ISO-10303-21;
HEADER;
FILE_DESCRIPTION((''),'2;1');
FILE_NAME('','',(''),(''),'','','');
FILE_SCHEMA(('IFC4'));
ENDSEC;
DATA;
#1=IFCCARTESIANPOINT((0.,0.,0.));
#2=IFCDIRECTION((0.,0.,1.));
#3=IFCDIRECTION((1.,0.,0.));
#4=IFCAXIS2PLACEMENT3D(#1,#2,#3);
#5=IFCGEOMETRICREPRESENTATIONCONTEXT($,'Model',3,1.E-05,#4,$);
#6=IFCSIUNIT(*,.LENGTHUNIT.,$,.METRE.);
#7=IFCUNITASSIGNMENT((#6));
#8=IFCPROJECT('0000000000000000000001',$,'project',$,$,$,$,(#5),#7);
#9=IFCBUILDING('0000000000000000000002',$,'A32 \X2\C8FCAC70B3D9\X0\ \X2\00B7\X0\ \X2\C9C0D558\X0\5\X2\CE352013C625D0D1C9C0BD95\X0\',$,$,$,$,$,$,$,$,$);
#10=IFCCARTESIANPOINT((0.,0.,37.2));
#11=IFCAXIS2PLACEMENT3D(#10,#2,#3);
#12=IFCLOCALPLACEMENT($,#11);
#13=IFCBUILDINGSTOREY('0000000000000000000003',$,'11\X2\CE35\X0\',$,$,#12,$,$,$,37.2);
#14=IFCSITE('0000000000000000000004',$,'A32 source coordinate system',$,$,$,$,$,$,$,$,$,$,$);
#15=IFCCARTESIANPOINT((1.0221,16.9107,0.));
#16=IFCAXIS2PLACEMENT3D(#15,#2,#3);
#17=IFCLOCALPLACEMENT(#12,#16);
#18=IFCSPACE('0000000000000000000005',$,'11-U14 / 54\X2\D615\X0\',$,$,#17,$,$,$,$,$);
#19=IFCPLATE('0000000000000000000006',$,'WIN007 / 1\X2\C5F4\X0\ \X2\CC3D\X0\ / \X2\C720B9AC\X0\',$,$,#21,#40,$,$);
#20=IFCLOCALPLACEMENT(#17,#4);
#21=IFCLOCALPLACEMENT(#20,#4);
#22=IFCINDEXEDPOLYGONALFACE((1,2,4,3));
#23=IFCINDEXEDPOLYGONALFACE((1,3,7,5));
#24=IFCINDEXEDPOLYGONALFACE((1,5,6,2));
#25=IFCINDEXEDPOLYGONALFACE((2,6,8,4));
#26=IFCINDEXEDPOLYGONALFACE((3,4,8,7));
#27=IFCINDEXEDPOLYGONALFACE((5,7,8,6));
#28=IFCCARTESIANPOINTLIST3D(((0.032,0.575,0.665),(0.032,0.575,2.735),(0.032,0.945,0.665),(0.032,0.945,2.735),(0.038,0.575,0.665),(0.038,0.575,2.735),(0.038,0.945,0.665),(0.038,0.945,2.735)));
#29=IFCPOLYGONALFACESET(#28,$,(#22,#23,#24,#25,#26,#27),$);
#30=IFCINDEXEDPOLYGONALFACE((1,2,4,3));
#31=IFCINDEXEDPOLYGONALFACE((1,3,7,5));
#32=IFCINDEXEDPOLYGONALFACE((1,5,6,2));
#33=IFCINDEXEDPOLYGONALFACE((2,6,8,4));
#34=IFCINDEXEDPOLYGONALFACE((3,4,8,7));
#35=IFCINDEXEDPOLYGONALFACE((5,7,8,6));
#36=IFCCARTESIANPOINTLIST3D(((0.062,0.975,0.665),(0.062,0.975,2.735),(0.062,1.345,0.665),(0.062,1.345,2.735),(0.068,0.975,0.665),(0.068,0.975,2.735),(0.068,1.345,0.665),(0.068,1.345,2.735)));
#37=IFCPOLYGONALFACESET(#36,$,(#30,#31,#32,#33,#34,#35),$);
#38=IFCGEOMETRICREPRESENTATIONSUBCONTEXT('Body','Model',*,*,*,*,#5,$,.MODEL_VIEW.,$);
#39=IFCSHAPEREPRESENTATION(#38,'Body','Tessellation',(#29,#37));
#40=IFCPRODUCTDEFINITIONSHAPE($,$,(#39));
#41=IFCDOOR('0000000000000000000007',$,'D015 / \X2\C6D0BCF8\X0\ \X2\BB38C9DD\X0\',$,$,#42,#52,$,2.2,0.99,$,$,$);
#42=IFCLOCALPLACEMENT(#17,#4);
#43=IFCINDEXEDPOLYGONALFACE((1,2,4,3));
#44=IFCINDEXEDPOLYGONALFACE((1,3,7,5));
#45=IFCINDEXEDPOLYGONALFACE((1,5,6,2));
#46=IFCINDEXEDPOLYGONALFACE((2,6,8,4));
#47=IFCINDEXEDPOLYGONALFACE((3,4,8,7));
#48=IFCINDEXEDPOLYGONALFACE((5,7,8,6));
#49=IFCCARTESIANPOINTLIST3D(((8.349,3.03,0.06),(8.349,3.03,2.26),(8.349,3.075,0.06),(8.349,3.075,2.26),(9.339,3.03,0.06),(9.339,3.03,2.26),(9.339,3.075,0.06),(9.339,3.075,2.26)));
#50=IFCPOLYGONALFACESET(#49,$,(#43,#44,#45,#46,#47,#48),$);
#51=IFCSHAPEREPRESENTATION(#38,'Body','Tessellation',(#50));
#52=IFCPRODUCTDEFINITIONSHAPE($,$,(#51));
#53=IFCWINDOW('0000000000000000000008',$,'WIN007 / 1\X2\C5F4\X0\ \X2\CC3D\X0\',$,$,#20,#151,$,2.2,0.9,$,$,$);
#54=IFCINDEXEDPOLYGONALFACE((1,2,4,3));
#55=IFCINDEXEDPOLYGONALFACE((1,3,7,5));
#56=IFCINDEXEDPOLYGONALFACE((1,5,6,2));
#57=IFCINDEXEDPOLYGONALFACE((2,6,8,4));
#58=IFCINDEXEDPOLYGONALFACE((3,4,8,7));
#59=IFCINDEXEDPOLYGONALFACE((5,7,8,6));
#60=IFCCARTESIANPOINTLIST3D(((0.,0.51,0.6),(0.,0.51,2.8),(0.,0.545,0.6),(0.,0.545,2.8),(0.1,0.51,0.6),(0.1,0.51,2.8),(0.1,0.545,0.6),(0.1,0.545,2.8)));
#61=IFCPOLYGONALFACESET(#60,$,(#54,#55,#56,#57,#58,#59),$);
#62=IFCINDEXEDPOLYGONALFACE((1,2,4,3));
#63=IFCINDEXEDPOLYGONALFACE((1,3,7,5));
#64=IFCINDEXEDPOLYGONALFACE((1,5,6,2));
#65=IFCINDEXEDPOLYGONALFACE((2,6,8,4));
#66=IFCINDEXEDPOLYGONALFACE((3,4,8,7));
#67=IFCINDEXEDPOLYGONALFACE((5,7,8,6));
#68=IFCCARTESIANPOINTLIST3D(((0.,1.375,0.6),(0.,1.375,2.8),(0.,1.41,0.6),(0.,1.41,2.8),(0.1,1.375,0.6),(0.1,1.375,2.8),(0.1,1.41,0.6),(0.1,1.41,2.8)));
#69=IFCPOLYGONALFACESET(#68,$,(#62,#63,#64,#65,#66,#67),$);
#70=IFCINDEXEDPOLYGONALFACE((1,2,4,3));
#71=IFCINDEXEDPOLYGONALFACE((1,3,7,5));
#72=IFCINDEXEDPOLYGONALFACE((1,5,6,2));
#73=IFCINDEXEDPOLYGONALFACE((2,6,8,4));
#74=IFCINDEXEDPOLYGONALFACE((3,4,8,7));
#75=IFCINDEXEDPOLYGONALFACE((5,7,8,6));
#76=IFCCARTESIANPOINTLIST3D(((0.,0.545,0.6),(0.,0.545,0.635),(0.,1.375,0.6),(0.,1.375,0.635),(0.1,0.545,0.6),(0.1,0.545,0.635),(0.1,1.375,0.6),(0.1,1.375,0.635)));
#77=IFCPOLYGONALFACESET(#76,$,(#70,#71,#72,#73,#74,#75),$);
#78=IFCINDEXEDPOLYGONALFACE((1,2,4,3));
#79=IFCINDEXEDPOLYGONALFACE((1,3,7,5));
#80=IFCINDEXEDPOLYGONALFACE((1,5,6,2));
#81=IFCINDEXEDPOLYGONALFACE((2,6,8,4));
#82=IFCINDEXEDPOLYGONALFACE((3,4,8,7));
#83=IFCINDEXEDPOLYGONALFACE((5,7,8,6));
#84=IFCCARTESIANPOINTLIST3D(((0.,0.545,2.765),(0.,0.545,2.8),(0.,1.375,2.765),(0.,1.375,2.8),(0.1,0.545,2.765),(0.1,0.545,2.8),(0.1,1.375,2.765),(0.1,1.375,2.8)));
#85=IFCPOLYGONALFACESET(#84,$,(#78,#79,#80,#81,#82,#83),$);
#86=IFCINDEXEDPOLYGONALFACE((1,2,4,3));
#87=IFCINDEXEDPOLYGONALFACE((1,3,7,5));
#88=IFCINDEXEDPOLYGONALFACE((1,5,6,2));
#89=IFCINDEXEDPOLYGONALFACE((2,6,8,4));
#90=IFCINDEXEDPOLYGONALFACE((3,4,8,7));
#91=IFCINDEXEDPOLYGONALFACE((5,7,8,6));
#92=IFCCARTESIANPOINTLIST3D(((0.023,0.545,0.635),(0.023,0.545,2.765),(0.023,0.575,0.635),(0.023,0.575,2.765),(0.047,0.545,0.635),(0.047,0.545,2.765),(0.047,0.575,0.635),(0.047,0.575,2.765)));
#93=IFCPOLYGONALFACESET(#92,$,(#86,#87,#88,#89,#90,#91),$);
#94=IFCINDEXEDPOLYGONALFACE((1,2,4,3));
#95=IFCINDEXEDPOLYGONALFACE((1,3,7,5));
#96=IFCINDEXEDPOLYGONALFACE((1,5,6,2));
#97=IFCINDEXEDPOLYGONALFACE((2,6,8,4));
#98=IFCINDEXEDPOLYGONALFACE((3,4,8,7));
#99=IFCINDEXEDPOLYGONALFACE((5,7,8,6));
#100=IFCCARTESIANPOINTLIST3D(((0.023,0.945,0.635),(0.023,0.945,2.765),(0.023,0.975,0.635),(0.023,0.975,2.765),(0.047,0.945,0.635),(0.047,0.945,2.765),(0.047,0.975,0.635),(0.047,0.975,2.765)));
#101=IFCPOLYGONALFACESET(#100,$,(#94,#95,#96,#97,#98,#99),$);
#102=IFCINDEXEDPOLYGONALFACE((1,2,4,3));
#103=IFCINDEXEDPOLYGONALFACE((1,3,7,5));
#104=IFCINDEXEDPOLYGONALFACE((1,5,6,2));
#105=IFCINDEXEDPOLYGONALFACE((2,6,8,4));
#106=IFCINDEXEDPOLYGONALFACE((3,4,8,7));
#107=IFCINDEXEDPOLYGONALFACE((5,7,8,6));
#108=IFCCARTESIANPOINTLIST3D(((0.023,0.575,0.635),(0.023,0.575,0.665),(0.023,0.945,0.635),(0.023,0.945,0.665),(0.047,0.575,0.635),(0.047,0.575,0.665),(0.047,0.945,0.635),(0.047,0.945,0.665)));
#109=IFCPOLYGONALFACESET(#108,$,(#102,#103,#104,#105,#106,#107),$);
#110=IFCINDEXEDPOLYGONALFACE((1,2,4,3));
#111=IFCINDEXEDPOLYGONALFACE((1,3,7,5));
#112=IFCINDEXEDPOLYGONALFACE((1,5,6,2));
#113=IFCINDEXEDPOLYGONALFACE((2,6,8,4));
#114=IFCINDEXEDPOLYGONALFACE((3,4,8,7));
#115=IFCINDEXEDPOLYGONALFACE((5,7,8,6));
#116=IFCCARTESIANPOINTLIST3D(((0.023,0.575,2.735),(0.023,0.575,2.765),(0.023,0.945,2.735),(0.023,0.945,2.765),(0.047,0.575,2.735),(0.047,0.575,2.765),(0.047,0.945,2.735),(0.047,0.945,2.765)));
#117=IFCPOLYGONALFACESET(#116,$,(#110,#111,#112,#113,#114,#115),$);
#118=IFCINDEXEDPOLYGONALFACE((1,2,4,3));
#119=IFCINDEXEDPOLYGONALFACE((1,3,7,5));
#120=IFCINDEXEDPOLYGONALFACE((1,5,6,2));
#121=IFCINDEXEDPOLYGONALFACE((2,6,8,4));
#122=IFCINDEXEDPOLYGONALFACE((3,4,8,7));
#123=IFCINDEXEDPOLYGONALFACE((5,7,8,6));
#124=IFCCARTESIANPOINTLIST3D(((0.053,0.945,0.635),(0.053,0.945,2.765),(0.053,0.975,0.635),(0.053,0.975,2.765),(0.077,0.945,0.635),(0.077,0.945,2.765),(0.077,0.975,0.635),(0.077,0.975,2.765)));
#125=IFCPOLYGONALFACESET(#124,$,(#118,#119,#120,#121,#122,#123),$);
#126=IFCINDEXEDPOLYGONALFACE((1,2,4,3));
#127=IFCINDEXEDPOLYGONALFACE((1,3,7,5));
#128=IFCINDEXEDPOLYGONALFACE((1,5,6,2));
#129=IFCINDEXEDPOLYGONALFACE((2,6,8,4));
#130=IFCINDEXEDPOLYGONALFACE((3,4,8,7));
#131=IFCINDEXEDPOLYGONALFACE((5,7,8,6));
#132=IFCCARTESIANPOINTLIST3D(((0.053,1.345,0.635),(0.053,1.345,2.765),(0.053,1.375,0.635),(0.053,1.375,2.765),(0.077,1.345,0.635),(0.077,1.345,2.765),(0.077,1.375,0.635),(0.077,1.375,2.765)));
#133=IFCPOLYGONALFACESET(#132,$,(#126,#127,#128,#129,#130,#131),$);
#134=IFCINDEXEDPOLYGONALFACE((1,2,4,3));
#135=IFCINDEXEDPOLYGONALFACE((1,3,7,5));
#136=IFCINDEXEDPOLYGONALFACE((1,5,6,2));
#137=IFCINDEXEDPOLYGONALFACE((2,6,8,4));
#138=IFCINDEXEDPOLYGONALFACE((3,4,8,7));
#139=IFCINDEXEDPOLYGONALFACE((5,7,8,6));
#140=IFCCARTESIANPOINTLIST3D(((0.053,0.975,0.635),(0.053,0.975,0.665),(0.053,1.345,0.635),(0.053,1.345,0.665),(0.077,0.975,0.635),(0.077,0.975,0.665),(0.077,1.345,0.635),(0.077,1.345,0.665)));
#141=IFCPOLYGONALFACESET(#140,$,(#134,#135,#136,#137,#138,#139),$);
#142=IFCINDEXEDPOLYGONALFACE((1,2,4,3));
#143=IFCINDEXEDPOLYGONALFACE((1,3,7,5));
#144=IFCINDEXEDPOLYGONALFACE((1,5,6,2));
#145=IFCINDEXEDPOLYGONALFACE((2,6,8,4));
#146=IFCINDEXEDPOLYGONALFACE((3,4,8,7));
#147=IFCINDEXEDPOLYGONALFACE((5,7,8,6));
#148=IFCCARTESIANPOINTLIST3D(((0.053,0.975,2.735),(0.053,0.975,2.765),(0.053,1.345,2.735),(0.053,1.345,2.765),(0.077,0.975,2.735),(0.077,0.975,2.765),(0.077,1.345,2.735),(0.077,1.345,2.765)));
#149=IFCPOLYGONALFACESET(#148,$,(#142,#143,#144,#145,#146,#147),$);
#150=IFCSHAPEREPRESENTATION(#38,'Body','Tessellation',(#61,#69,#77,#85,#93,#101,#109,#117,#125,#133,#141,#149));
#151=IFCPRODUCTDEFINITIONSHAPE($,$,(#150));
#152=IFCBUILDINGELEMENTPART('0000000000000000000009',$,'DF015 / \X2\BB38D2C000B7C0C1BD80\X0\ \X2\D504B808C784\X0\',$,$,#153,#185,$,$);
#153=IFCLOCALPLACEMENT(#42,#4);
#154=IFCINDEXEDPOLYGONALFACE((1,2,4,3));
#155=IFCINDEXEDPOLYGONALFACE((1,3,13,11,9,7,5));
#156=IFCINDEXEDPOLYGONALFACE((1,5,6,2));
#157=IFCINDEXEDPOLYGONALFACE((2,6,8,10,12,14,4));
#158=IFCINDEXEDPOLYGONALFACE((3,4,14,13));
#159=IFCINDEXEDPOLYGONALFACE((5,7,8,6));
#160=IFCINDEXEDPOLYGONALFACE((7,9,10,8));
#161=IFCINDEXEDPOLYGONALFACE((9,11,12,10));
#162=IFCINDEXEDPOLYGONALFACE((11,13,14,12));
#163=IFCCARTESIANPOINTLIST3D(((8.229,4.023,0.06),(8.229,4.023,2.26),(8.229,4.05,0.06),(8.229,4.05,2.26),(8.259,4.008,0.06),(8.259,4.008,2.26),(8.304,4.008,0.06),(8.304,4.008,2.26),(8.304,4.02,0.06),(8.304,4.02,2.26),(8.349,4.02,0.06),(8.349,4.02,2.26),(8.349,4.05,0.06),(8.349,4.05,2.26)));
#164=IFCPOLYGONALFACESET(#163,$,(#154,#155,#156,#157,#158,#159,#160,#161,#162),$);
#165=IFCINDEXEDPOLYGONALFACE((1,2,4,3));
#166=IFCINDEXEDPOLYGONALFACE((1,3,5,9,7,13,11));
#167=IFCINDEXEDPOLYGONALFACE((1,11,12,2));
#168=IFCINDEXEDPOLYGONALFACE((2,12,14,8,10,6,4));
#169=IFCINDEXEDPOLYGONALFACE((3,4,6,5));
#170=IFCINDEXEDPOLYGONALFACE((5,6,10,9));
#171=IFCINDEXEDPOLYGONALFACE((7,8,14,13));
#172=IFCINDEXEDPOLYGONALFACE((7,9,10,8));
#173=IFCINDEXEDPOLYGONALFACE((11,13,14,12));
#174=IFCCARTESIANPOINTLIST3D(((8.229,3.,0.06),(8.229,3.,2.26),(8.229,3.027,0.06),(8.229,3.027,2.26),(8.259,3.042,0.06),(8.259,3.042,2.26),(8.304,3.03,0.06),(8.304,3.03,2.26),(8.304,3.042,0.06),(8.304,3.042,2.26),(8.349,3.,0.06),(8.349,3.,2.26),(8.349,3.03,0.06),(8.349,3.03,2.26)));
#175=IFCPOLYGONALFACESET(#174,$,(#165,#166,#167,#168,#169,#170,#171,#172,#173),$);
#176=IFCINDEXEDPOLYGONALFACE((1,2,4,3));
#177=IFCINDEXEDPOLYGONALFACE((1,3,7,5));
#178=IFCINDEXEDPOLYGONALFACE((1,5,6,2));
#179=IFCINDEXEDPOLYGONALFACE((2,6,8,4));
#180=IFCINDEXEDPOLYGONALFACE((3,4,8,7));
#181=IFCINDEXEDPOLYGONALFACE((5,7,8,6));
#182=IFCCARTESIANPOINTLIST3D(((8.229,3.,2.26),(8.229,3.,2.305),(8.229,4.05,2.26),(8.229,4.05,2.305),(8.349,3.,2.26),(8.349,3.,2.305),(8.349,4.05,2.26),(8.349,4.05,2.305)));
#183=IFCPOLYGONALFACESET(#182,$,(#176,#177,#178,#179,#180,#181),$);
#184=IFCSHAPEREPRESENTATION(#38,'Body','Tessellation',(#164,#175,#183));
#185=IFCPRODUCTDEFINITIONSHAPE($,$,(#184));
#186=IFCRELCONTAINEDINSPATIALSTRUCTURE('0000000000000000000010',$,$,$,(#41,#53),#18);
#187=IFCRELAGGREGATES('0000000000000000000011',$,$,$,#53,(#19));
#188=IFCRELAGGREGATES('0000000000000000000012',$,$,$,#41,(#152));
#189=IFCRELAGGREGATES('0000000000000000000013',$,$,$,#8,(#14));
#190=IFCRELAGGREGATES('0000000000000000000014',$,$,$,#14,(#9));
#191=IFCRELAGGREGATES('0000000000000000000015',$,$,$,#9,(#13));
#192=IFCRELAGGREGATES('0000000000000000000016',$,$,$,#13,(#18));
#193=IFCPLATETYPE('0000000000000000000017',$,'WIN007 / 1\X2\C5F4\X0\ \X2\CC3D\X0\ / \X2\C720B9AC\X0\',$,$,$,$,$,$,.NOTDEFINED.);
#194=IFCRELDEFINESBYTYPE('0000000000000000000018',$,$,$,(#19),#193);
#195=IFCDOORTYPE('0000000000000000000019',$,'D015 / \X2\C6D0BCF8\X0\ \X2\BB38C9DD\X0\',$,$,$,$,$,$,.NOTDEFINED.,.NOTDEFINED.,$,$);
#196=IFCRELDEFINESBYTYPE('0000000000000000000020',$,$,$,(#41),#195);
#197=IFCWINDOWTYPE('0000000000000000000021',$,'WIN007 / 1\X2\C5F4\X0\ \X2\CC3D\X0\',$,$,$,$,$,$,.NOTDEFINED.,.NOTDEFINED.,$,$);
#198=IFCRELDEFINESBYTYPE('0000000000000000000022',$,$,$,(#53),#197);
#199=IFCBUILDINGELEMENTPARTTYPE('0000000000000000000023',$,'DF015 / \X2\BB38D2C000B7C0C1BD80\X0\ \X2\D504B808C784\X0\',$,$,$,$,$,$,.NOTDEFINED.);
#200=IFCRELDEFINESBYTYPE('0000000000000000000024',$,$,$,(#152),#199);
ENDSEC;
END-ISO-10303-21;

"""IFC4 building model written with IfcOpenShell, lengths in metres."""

from ifc_helpers import new_model, si_unit, frame, origin, origin_with_axes, place, context, subcontext, project, spatial, polyline, outline, extrude, source, transform, mapped, type_object, type_shapes, element, aggregate, save


model = new_model("IFC4")

# Units and contexts
model_context = context("Model", 3, precision=1e-05, world=origin_with_axes())
body_context = subcontext(model_context, "Body", "Model", "MODEL_VIEW")
ifc_project = project(units=[si_unit("LENGTHUNIT", "METRE")], contexts=[model_context])

# Plate
plate_type_1 = type_object("IfcPlateType", Name="WIN007 / 1열 창 / 유리", PredefinedType="NOTDEFINED")
shared_shape_1 = source(origin(), body_context, "Body", "SweptSolid", [
    extrude(outline(polyline([(0.032, 0.575), (0.032, 0.945), (0.038, 0.945), (0.038, 0.575), (0.032, 0.575)])), frame((0.0, 0.0, 0.665)), (0.0, 0.0, 1.0), 2.07),
    extrude(outline(polyline([(0.062, 0.975), (0.062, 1.345), (0.068, 1.345), (0.068, 0.975), (0.062, 0.975)])), frame((0.0, 0.0, 0.665)), (0.0, 0.0, 1.0), 2.07),
])
type_shapes(plate_type_1, [shared_shape_1])
storey_placement = place(None, frame((0.0, 0.0, 37.2), z_axis=(0.0, 0.0, 1.0), x_axis=(1.0, 0.0, 0.0)))
space_1_placement = place(storey_placement, frame((1.0221, 16.9107, 0.0), z_axis=(0.0, 0.0, 1.0), x_axis=(1.0, 0.0, 0.0)))
window_1_placement = place(space_1_placement, origin_with_axes())
plate_1_placement = place(window_1_placement, origin_with_axes())
plate_1 = element("IfcPlate", 1, at=plate_1_placement, type_object=plate_type_1, Name="WIN007 / 1열 창 / 유리", context=body_context, shape_type="MappedRepresentation", body=[
    mapped(shared_shape_1, transform((0.0, 0.0, 0.0), scale=1.0)),
])

# Site, building, storey, space
site = spatial("IfcSite", under=ifc_project, Name="A32 source coordinate system")
building = spatial("IfcBuilding", under=site, Name="A32 주거동 · 지하5층–옥탑지붕")
storey = spatial("IfcBuildingStorey", under=building, at=storey_placement, Name="11층", Elevation=37.2)
space_1 = spatial("IfcSpace", under=storey, at=space_1_placement, Name="11-U14 / 54형")

# Door
door_type_1 = type_object("IfcDoorType", Name="D015 / 원본 문짝", OperationType="NOTDEFINED", PredefinedType="NOTDEFINED")
shared_shape_2 = source(origin(), body_context, "Body", "SweptSolid", [
    extrude(outline(polyline([(9.339, 3.075), (9.339, 3.03), (8.349, 3.03), (8.349, 3.075), (9.339, 3.075)])), frame((0.0, 0.0, 0.06)), (0.0, 0.0, 1.0), 2.2),
])
type_shapes(door_type_1, [shared_shape_2])
door_1_placement = place(space_1_placement, origin_with_axes())
door_1 = element("IfcDoor", 2, at=door_1_placement, inside=space_1, type_object=door_type_1, Name="D015 / 원본 문짝", OverallHeight=2.2, OverallWidth=0.99, context=body_context, shape_type="MappedRepresentation", body=[
    mapped(shared_shape_2, transform((0.0, 0.0, 0.0), scale=1.0)),
])

# Window
window_type_1 = type_object("IfcWindowType", Name="WIN007 / 1열 창", PartitioningType="NOTDEFINED", PredefinedType="NOTDEFINED")
shared_shape_3 = source(origin(), body_context, "Body", "SweptSolid", [
    extrude(outline(polyline([(0.0, 0.51), (0.0, 0.545), (0.1, 0.545), (0.1, 0.51), (0.0, 0.51)])), frame((0.0, 0.0, 0.6)), (0.0, 0.0, 1.0), 2.2),
    extrude(outline(polyline([(0.0, 1.375), (0.0, 1.41), (0.1, 1.41), (0.1, 1.375), (0.0, 1.375)])), frame((0.0, 0.0, 0.6)), (0.0, 0.0, 1.0), 2.2),
    extrude(outline(polyline([(0.0, 0.545), (0.0, 1.375), (0.1, 1.375), (0.1, 0.545), (0.0, 0.545)])), frame((0.0, 0.0, 0.6)), (0.0, 0.0, 1.0), 0.035),
    extrude(outline(polyline([(0.0, 0.545), (0.0, 1.375), (0.1, 1.375), (0.1, 0.545), (0.0, 0.545)])), frame((0.0, 0.0, 2.765)), (0.0, 0.0, 1.0), 0.035),
    extrude(outline(polyline([(0.023, 0.545), (0.023, 0.575), (0.047, 0.575), (0.047, 0.545), (0.023, 0.545)])), frame((0.0, 0.0, 0.635)), (0.0, 0.0, 1.0), 2.13),
    extrude(outline(polyline([(0.023, 0.945), (0.023, 0.975), (0.047, 0.975), (0.047, 0.945), (0.023, 0.945)])), frame((0.0, 0.0, 0.635)), (0.0, 0.0, 1.0), 2.13),
    extrude(outline(polyline([(0.023, 0.575), (0.023, 0.945), (0.047, 0.945), (0.047, 0.575), (0.023, 0.575)])), frame((0.0, 0.0, 0.635)), (0.0, 0.0, 1.0), 0.03),
    extrude(outline(polyline([(0.023, 0.575), (0.023, 0.945), (0.047, 0.945), (0.047, 0.575), (0.023, 0.575)])), frame((0.0, 0.0, 2.735)), (0.0, 0.0, 1.0), 0.03),
    extrude(outline(polyline([(0.053, 0.945), (0.053, 0.975), (0.077, 0.975), (0.077, 0.945), (0.053, 0.945)])), frame((0.0, 0.0, 0.635)), (0.0, 0.0, 1.0), 2.13),
    extrude(outline(polyline([(0.053, 1.345), (0.053, 1.375), (0.077, 1.375), (0.077, 1.345), (0.053, 1.345)])), frame((0.0, 0.0, 0.635)), (0.0, 0.0, 1.0), 2.13),
    extrude(outline(polyline([(0.053, 0.975), (0.053, 1.345), (0.077, 1.345), (0.077, 0.975), (0.053, 0.975)])), frame((0.0, 0.0, 0.635)), (0.0, 0.0, 1.0), 0.03),
    extrude(outline(polyline([(0.053, 0.975), (0.053, 1.345), (0.077, 1.345), (0.077, 0.975), (0.053, 0.975)])), frame((0.0, 0.0, 2.735)), (0.0, 0.0, 1.0), 0.03),
])
type_shapes(window_type_1, [shared_shape_3])
window_1 = element("IfcWindow", 3, at=window_1_placement, inside=space_1, type_object=window_type_1, Name="WIN007 / 1열 창", OverallHeight=2.2, OverallWidth=0.9, context=body_context, shape_type="MappedRepresentation", body=[
    mapped(shared_shape_3, transform((0.0, 0.0, 0.0), scale=1.0)),
])
aggregate(window_1, [plate_1])

# Building element part
building_element_part_type_1 = type_object("IfcBuildingElementPartType", Name="DF015 / 문틀·상부 프레임", PredefinedType="NOTDEFINED")
shared_shape_4 = source(origin(), body_context, "Body", "SweptSolid", [
    extrude(outline(polyline([(8.349, 4.02), (8.304, 4.02), (8.304, 4.008), (8.259, 4.008), (8.229, 4.023), (8.229, 4.05), (8.349, 4.05), (8.349, 4.02)])), frame((0.0, 0.0, 0.06)), (0.0, 0.0, 1.0), 2.2),
    extrude(outline(polyline([(8.229, 3.0), (8.229, 3.027), (8.259, 3.042), (8.304, 3.042), (8.304, 3.03), (8.349, 3.03), (8.349, 3.0), (8.229, 3.0)])), frame((0.0, 0.0, 0.06)), (0.0, 0.0, 1.0), 2.2),
    extrude(outline(polyline([(8.229, 3.0), (8.229, 4.05), (8.349, 4.05), (8.349, 3.0), (8.229, 3.0)])), frame((0.0, 0.0, 2.26)), (0.0, 0.0, 1.0), 0.045),
])
type_shapes(building_element_part_type_1, [shared_shape_4])
building_element_part_1_placement = place(door_1_placement, origin_with_axes())
building_element_part_1 = element("IfcBuildingElementPart", 4, at=building_element_part_1_placement, type_object=building_element_part_type_1, Name="DF015 / 문틀·상부 프레임", context=body_context, shape_type="MappedRepresentation", body=[
    mapped(shared_shape_4, transform((0.0, 0.0, 0.0), scale=1.0)),
])
aggregate(door_1, [building_element_part_1])

save(model, "model.ifc")
